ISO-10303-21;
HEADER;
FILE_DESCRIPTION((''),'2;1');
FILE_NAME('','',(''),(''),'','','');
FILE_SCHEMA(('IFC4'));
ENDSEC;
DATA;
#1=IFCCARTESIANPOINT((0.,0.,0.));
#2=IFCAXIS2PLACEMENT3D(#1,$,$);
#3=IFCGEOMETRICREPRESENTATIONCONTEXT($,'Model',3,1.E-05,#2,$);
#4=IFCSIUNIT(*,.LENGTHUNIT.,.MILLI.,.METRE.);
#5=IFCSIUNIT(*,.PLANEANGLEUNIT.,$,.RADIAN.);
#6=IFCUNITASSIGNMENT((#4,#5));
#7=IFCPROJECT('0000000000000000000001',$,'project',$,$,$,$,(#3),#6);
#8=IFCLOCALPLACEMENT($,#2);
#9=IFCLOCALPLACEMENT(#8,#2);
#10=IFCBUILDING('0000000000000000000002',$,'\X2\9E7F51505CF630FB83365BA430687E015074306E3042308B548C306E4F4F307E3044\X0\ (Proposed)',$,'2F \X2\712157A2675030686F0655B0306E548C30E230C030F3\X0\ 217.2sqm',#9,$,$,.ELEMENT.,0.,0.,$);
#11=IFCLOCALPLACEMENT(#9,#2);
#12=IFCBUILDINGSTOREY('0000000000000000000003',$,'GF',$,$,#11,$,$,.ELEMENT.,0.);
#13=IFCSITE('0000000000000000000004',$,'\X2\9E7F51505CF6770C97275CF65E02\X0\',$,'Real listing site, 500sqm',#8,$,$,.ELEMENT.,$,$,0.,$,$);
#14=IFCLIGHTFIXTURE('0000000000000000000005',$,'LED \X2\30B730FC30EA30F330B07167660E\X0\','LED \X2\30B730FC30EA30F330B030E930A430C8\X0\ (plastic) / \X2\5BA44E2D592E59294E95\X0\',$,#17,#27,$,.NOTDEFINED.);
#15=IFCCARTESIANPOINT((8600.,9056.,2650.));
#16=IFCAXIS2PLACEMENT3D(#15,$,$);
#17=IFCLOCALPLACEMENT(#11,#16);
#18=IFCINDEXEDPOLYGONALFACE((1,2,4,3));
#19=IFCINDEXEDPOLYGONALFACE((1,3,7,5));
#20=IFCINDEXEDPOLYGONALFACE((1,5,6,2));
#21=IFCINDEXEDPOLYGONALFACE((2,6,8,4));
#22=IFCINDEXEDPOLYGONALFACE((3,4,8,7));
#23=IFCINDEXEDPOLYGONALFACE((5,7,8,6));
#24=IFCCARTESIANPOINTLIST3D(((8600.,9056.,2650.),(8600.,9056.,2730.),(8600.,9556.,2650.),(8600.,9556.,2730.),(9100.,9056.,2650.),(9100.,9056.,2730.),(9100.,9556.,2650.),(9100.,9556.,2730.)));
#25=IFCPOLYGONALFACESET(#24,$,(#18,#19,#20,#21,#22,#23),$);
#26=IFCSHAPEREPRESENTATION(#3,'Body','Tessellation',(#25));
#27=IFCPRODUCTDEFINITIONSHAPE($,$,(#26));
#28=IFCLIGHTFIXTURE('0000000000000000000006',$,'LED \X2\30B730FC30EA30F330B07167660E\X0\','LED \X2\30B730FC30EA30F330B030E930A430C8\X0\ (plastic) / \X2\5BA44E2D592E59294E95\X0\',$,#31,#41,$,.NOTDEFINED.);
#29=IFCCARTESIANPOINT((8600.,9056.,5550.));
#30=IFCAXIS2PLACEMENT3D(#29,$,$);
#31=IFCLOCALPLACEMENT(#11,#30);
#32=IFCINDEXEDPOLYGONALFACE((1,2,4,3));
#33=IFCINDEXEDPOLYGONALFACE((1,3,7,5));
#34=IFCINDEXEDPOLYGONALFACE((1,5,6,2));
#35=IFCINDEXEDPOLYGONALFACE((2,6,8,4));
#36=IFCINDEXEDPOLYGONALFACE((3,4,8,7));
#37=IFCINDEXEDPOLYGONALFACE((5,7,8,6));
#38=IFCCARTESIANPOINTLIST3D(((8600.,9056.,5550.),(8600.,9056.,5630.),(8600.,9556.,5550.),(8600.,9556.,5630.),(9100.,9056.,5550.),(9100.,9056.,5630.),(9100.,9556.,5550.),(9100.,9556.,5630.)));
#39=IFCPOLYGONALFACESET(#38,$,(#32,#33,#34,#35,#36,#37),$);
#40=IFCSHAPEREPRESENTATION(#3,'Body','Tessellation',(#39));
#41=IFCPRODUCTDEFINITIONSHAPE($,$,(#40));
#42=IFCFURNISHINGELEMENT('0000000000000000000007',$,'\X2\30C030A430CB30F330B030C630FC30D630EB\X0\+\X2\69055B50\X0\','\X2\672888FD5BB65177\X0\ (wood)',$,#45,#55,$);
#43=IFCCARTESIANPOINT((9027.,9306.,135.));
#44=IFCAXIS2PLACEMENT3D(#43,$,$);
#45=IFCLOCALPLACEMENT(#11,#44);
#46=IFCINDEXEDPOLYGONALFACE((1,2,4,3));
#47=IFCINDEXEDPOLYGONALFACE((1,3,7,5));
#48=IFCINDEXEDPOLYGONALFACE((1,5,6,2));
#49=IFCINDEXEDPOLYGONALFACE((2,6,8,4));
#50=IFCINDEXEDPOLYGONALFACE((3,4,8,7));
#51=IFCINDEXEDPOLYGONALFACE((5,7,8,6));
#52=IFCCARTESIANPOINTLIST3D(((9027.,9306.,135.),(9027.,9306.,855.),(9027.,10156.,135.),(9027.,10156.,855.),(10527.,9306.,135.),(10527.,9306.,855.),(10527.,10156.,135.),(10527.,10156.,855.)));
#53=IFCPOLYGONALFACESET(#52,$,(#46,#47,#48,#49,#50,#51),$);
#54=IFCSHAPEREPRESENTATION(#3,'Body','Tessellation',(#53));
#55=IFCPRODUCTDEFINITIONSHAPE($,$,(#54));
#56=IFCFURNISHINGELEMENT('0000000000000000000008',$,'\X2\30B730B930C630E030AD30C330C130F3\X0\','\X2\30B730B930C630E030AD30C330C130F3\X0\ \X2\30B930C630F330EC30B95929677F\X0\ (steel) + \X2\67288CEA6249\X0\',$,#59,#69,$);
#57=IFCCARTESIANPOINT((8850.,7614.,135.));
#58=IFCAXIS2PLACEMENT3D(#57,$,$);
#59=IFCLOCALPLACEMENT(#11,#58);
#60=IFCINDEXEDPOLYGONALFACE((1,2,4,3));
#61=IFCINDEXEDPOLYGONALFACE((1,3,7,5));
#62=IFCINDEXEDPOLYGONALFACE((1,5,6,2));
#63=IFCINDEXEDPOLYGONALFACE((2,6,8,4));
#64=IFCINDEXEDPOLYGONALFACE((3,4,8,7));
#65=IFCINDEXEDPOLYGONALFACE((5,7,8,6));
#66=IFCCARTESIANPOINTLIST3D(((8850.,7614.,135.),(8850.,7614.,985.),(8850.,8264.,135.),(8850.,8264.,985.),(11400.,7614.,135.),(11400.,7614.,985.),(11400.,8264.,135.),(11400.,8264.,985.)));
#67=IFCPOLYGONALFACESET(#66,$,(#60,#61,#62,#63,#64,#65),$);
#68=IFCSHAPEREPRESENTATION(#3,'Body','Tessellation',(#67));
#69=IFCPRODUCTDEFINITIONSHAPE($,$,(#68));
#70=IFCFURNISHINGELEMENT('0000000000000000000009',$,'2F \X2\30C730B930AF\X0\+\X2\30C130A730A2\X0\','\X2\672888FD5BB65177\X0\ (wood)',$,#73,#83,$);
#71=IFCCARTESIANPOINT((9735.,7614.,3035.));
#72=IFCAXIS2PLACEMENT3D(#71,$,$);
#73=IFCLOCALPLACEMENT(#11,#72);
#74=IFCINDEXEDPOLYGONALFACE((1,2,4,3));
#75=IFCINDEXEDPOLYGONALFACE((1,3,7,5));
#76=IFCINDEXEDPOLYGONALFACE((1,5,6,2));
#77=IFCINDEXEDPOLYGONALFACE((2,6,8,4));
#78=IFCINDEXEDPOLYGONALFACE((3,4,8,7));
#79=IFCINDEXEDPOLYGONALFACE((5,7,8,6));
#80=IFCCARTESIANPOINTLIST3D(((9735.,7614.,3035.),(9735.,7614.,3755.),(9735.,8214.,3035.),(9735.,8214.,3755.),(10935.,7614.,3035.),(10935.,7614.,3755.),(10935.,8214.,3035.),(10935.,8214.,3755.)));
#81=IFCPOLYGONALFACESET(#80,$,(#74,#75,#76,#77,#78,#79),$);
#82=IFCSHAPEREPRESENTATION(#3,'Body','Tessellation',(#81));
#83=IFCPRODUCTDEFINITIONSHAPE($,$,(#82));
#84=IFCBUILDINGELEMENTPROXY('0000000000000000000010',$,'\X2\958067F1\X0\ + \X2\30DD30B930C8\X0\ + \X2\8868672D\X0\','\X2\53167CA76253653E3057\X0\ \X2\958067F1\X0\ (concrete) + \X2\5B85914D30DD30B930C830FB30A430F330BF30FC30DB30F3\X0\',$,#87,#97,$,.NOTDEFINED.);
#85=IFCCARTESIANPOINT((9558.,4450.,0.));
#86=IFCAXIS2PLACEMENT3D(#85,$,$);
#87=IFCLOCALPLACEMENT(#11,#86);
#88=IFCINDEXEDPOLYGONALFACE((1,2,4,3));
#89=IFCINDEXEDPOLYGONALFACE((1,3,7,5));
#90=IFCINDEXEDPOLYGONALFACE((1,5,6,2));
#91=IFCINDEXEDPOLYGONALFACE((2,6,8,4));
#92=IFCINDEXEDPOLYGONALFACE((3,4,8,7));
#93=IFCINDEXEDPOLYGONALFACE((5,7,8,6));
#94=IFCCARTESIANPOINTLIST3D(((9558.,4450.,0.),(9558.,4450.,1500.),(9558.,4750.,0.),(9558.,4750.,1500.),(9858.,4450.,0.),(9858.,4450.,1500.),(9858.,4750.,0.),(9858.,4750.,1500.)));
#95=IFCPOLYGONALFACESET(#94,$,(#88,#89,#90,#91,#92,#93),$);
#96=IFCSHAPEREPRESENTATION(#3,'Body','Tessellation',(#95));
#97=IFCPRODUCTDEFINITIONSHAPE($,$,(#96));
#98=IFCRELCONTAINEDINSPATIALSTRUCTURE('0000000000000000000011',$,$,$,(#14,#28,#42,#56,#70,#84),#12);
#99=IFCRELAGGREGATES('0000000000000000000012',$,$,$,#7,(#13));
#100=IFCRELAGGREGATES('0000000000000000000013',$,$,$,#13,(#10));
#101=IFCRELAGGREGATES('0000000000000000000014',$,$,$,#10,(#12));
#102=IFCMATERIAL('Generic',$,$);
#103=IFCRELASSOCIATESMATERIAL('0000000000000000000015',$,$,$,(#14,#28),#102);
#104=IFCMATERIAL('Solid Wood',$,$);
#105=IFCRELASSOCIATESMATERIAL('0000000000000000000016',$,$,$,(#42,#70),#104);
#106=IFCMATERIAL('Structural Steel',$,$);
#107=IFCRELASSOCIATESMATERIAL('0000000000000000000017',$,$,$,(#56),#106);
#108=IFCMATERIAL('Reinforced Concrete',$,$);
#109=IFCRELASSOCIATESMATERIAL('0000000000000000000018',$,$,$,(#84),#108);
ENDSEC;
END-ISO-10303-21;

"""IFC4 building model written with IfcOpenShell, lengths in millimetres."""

from ifc_helpers import new_model, si_unit, frame, frame_2d, origin, place, context, project, spatial, rectangle, extrude, material, element, save


model = new_model("IFC4")

# Units and contexts
model_context = context("Model", 3, precision=1e-05, world=origin())
ifc_project = project(units=[si_unit("LENGTHUNIT", "METRE", prefix="MILLI"), si_unit("PLANEANGLEUNIT", "RADIAN")], contexts=[model_context])

# Site, building, storey
site_placement = place(None, origin())
site = spatial("IfcSite", under=ifc_project, at=site_placement, Name="鹿児島県霧島市", ObjectType="Real listing site, 500sqm", CompositionType="ELEMENT", RefElevation=0.0)
building_placement = place(site_placement, origin())
building = spatial("IfcBuilding", under=site, at=building_placement, Name="鹿児島・茶室と縁側のある和の住まい (Proposed)", ObjectType="2F 無垢材と漆喰の和モダン 217.2sqm", CompositionType="ELEMENT", ElevationOfRefHeight=0.0, ElevationOfTerrain=0.0)
storey_placement = place(building_placement, origin())
storey = spatial("IfcBuildingStorey", under=building, at=storey_placement, Name="GF", CompositionType="ELEMENT", Elevation=0.0)

# Shared definitions
ifc_material_1 = material(Name="Solid Wood")

# Shared definitions
ifc_material_2 = material(Name="Structural Steel")

# Shared definitions
ifc_material_3 = material(Name="Reinforced Concrete")

# Shared definitions
ifc_material_4 = material(Name="Generic")

# Light fixtures
light_fixture_1_placement = place(storey_placement, frame((8600.0, 9056.0, 2650.0)))
element("IfcLightFixture", 1, at=light_fixture_1_placement, inside=storey, material=ifc_material_4, Name="LED シーリング照明", Description="LED シーリングライト (plastic) / 室中央天井", PredefinedType="NOTDEFINED", context=model_context, shape_type="SweptSolid", body=[
    extrude(rectangle(XDim=500.0, YDim=500.0, at=frame_2d((250.0, 250.0))), frame((8600.0, 9056.0, 2650.0)), (0.0, 0.0, 1.0), 80.0),
])
light_fixture_2_placement = place(storey_placement, frame((8600.0, 9056.0, 5550.0)))
element("IfcLightFixture", 2, at=light_fixture_2_placement, inside=storey, material=ifc_material_4, Name="LED シーリング照明", Description="LED シーリングライト (plastic) / 室中央天井", PredefinedType="NOTDEFINED", context=model_context, shape_type="SweptSolid", body=[
    extrude(rectangle(XDim=500.0, YDim=500.0, at=frame_2d((250.0, 250.0))), frame((8600.0, 9056.0, 5550.0)), (0.0, 0.0, 1.0), 80.0),
])

# Furnishing elements
furnishing_1_placement = place(storey_placement, frame((9027.0, 9306.0, 135.0)))
element("IfcFurnishingElement", 3, at=furnishing_1_placement, inside=storey, material=ifc_material_1, Name="ダイニングテーブル+椅子", Description="木製家具 (wood)", context=model_context, shape_type="SweptSolid", body=[
    extrude(rectangle(XDim=1500.0, YDim=850.0, at=frame_2d((750.0, 425.0))), frame((9027.0, 9306.0, 135.0)), (0.0, 0.0, 1.0), 720.0),
])
furnishing_2_placement = place(storey_placement, frame((8850.0, 7614.0, 135.0)))
element("IfcFurnishingElement", 4, at=furnishing_2_placement, inside=storey, material=ifc_material_2, Name="システムキッチン", Description="システムキッチン ステンレス天板 (steel) + 木質扉", context=model_context, shape_type="SweptSolid", body=[
    extrude(rectangle(XDim=2550.0, YDim=650.0, at=frame_2d((1275.0, 325.0))), frame((8850.0, 7614.0, 135.0)), (0.0, 0.0, 1.0), 850.0),
])
furnishing_3_placement = place(storey_placement, frame((9735.0, 7614.0, 3035.0)))
element("IfcFurnishingElement", 5, at=furnishing_3_placement, inside=storey, material=ifc_material_1, Name="2F デスク+チェア", Description="木製家具 (wood)", context=model_context, shape_type="SweptSolid", body=[
    extrude(rectangle(XDim=1200.0, YDim=600.0, at=frame_2d((600.0, 300.0))), frame((9735.0, 7614.0, 3035.0)), (0.0, 0.0, 1.0), 720.0),
])

# Building element proxy
proxy_placement = place(storey_placement, frame((9558.0, 4450.0, 0.0)))
element("IfcBuildingElementProxy", 6, at=proxy_placement, inside=storey, material=ifc_material_3, Name="門柱 + ポスト + 表札", Description="化粧打放し 門柱 (concrete) + 宅配ポスト・インターホン", PredefinedType="NOTDEFINED", context=model_context, shape_type="SweptSolid", body=[
    extrude(rectangle(XDim=300.0, YDim=300.0, at=frame_2d((150.0, 150.0))), frame((9558.0, 4450.0, 0.0)), (0.0, 0.0, 1.0), 1500.0),
])

save(model, "model.ifc")
